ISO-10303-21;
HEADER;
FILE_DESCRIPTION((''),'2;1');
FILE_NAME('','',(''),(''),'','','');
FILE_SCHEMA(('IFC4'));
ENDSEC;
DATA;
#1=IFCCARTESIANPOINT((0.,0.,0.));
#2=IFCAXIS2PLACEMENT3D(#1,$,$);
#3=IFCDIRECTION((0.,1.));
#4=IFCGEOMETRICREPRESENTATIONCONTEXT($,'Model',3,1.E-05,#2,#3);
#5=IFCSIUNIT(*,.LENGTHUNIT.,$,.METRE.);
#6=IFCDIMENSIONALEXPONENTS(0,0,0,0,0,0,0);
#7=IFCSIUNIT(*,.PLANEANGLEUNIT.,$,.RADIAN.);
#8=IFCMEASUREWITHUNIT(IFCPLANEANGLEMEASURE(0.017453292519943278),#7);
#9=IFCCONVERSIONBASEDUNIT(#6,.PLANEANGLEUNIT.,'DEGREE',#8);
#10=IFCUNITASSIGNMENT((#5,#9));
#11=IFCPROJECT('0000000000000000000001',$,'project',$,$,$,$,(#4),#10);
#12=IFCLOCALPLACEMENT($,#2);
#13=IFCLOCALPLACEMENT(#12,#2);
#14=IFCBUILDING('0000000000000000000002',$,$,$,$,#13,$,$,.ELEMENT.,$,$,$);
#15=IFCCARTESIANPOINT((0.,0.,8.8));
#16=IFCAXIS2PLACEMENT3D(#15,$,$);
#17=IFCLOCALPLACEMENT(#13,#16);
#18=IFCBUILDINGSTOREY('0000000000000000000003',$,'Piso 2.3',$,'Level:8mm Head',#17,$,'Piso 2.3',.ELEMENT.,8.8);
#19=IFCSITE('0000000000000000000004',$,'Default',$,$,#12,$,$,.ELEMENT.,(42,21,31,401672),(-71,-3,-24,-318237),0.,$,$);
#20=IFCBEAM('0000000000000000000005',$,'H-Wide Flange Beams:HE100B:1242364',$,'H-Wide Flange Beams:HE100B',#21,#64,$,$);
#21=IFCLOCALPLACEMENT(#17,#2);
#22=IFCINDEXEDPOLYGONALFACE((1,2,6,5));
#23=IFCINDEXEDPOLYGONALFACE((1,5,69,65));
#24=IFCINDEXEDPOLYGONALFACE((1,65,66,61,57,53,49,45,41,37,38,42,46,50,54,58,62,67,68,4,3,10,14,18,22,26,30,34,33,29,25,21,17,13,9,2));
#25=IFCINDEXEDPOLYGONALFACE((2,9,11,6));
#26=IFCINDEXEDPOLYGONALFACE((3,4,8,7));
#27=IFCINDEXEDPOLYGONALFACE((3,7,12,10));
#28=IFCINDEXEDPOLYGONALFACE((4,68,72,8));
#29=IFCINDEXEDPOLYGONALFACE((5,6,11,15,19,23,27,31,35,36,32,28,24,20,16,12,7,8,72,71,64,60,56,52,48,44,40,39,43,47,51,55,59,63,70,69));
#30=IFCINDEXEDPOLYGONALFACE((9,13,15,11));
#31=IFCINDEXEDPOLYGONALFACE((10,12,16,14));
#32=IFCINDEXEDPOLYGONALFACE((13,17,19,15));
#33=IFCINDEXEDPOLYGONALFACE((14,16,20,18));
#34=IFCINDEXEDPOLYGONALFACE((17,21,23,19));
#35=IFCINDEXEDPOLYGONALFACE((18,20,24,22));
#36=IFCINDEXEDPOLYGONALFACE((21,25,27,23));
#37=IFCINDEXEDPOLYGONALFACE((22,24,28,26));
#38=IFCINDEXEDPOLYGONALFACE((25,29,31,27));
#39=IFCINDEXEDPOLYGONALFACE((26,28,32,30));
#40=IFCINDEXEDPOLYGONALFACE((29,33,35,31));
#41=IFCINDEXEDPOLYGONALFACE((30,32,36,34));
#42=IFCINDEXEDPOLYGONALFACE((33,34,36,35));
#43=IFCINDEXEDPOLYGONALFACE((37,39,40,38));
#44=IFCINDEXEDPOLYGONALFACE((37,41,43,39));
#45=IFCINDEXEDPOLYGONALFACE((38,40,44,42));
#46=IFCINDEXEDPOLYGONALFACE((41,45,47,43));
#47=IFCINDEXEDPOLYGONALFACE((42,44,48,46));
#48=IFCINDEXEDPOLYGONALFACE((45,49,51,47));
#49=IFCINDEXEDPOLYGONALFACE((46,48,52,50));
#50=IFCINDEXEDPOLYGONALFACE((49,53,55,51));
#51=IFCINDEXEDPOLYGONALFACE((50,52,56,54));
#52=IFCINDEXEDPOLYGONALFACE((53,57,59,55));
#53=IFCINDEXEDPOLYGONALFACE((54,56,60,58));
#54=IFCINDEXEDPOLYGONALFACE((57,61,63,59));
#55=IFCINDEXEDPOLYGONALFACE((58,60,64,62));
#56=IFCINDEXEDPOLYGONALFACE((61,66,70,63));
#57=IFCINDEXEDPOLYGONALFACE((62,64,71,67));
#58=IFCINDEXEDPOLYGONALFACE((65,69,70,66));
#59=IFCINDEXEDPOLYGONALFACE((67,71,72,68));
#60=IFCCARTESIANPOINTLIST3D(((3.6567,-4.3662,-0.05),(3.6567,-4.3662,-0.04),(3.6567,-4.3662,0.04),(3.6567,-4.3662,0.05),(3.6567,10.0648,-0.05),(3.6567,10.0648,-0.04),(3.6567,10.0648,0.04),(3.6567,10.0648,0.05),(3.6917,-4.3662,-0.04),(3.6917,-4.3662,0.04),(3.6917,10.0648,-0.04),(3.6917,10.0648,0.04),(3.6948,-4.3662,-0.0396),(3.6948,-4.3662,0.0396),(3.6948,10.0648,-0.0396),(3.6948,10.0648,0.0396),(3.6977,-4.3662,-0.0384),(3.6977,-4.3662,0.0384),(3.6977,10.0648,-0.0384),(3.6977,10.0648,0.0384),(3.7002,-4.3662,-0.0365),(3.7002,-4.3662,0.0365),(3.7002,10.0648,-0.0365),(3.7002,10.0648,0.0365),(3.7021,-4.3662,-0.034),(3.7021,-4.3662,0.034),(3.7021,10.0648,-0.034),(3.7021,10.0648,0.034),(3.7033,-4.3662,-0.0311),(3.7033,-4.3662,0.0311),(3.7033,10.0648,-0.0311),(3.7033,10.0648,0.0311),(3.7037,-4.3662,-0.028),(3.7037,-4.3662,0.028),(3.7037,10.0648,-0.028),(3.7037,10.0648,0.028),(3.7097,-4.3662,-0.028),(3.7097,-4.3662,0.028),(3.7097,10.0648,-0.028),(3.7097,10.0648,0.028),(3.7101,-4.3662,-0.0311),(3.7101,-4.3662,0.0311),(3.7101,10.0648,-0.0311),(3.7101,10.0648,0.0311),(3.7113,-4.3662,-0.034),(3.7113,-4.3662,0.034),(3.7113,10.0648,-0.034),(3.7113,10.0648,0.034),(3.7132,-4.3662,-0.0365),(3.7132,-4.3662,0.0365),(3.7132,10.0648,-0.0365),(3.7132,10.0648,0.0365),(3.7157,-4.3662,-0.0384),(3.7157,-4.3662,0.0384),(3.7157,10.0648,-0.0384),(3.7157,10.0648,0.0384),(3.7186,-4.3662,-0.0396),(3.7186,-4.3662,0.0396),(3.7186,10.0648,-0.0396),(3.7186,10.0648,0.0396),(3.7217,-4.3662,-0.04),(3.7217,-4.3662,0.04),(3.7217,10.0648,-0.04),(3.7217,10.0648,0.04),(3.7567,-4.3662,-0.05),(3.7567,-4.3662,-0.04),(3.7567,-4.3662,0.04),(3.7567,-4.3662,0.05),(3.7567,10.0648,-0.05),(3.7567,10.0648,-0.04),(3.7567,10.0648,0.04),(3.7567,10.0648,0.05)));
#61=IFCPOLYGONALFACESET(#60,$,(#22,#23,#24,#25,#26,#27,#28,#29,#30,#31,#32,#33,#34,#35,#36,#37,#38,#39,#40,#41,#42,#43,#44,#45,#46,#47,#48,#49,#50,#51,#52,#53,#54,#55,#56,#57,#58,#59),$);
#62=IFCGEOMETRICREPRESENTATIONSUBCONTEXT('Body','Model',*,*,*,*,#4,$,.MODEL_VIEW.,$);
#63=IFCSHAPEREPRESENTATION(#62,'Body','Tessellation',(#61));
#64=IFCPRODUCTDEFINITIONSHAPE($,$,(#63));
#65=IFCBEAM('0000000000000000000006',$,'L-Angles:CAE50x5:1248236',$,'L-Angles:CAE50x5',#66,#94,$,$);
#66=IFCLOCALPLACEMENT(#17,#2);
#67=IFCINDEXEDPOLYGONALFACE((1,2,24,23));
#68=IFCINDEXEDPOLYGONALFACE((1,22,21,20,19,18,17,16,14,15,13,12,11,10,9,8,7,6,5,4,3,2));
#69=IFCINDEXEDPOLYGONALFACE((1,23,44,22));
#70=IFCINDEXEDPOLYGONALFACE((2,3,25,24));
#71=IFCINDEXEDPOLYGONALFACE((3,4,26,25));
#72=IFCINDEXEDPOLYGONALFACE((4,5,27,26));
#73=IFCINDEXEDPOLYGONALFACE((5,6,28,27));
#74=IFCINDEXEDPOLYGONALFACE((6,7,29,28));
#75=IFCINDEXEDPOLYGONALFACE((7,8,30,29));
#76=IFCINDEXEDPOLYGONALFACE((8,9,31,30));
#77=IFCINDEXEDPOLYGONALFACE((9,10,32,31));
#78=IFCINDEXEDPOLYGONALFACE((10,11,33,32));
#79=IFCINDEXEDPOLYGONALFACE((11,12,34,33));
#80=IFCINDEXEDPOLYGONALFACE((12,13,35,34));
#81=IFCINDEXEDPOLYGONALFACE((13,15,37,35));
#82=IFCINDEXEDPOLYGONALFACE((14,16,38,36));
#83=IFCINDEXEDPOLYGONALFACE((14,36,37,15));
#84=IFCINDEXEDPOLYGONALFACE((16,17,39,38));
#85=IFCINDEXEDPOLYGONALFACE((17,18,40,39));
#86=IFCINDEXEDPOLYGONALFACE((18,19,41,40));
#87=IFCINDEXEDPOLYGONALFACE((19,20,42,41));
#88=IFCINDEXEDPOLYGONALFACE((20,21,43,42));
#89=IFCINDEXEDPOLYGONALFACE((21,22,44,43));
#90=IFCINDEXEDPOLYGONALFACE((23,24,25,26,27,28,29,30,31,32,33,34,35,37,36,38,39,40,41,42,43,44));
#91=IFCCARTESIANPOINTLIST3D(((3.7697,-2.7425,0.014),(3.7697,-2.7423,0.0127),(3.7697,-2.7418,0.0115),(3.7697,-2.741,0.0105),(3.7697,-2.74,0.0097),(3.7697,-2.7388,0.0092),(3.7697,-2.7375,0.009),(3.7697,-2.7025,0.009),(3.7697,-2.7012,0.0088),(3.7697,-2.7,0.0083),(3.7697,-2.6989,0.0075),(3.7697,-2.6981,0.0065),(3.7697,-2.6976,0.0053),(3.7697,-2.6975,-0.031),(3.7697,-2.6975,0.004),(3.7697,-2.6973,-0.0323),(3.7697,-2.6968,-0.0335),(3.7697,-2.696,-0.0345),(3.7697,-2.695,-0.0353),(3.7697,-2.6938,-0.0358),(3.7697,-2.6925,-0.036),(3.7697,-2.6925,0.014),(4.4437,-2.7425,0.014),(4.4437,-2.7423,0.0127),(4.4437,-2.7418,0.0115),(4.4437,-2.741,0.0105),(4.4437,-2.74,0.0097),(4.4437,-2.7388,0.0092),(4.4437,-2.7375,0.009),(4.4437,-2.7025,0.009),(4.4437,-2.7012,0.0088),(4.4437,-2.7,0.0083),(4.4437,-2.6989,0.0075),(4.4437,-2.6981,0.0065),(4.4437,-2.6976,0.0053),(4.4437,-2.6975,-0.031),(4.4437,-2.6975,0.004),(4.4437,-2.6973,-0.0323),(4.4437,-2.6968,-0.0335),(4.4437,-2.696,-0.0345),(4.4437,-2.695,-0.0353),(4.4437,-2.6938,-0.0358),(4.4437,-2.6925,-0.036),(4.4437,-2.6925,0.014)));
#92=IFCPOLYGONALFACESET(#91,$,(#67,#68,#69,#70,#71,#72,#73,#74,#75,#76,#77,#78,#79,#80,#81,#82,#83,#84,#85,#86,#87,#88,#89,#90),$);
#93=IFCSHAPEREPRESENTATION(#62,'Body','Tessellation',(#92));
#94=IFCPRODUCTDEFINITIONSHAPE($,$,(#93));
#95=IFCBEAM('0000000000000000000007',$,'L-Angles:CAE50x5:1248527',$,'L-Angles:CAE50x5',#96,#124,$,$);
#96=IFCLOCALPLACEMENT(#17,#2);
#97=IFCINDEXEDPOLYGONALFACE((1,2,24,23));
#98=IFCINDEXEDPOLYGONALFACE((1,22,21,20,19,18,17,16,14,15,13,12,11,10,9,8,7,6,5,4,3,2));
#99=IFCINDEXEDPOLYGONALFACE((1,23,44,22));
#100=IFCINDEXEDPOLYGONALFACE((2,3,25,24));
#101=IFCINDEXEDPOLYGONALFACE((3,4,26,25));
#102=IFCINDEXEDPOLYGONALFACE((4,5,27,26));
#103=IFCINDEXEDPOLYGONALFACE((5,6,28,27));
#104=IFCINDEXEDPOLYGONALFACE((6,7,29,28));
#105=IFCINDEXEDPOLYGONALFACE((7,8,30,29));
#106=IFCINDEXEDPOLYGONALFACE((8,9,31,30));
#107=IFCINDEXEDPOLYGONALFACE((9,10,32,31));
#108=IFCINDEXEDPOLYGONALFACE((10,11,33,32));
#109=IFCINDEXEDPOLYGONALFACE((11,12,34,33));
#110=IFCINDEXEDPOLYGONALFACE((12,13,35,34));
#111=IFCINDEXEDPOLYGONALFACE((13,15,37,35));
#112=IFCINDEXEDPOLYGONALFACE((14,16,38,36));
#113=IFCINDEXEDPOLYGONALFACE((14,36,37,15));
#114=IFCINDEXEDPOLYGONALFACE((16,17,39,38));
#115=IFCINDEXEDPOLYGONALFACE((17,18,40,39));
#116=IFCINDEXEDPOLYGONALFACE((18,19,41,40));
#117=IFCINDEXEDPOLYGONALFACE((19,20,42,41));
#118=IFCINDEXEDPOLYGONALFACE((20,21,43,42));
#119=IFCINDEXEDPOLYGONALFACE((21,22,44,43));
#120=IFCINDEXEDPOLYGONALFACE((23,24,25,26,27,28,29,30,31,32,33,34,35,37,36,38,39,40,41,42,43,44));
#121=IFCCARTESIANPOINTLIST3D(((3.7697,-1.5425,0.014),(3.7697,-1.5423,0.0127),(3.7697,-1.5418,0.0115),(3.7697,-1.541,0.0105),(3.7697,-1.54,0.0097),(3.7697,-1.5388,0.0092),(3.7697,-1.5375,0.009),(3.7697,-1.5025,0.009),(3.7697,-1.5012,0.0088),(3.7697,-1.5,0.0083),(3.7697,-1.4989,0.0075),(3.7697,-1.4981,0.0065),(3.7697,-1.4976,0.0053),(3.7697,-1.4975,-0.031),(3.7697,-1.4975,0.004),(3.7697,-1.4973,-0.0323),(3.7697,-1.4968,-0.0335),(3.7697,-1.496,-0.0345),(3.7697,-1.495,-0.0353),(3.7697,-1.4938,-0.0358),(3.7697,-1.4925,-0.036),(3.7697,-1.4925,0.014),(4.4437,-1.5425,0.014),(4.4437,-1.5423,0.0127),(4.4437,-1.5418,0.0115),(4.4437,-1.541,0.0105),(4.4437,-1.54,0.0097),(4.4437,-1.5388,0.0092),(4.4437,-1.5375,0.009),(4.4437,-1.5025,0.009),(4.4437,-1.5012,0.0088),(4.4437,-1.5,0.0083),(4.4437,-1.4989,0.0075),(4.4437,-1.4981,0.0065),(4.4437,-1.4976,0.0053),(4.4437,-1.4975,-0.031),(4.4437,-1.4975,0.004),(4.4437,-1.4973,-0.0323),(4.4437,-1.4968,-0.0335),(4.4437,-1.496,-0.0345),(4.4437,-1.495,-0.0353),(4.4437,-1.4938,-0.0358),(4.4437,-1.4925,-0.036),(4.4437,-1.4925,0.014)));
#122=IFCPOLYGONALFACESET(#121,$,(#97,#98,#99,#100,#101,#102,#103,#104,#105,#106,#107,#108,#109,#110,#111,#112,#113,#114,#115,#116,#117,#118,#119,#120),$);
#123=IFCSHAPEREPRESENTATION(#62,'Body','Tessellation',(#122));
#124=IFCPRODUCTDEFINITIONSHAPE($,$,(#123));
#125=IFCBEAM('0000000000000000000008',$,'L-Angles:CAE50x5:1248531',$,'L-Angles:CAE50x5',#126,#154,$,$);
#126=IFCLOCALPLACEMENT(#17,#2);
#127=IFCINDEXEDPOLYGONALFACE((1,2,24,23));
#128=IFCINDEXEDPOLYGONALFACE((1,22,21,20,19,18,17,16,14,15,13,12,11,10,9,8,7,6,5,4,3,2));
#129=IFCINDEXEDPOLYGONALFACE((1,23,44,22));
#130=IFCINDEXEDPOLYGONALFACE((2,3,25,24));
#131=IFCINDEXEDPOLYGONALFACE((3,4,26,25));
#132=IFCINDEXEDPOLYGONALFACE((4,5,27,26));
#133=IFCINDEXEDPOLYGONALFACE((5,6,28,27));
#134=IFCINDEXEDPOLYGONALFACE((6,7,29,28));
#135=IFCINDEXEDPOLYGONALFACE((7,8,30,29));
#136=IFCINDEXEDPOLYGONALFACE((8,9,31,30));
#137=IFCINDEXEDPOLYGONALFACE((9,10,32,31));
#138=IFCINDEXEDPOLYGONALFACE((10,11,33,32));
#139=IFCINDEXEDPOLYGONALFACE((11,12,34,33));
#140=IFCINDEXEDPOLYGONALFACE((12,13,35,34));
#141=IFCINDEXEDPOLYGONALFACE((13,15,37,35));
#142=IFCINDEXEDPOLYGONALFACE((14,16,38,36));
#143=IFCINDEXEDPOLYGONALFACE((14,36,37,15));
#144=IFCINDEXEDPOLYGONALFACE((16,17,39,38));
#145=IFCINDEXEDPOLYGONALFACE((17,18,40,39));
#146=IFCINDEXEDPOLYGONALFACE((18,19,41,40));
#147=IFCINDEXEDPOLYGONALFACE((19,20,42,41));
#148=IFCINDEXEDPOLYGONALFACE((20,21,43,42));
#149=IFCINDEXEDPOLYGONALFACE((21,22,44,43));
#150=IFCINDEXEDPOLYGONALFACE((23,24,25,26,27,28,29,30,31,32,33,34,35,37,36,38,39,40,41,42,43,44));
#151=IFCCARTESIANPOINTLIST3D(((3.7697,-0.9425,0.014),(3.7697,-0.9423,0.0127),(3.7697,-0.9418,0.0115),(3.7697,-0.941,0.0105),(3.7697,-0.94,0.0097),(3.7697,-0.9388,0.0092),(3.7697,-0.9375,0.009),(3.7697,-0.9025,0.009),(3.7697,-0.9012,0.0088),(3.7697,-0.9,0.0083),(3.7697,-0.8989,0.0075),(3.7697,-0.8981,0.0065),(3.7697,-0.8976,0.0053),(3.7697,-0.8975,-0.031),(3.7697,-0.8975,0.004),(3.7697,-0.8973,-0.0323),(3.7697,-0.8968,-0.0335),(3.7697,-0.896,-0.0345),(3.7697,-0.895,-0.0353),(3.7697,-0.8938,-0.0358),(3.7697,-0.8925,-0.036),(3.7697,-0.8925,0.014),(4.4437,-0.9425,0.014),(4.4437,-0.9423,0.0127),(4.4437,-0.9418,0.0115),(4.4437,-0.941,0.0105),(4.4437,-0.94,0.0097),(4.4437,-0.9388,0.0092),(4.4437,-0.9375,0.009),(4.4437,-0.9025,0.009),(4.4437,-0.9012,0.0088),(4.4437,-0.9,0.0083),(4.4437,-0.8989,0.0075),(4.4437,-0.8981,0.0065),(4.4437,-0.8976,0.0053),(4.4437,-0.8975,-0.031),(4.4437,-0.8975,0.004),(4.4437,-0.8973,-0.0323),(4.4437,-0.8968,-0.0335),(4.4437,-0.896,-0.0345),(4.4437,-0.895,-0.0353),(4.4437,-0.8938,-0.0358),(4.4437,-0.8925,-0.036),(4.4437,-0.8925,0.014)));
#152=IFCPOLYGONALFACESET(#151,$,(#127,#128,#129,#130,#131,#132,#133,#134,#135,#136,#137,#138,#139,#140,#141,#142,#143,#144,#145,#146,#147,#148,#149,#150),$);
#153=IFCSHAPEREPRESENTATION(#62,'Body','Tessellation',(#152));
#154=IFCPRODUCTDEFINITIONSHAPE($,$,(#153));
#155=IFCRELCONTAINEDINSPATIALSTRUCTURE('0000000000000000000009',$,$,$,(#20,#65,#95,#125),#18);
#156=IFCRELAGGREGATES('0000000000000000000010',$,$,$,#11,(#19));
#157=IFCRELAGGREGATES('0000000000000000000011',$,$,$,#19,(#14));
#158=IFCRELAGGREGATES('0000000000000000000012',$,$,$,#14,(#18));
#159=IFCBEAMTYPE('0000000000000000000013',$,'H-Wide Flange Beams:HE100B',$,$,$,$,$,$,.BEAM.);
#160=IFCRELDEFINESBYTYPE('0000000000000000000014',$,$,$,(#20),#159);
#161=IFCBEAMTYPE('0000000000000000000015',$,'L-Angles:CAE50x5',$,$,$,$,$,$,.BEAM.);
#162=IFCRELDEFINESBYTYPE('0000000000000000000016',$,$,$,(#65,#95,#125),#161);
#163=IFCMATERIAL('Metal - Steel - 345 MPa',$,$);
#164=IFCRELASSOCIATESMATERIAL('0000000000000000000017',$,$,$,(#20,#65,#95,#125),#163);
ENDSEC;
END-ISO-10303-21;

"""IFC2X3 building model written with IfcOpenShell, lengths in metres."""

from ifc_helpers import new_model, entity, si_unit, converted_unit, direction, frame, frame_2d, origin, place, context, subcontext, project, spatial, polyline, circle_curve, parameter, trimmed, segment, composite_curve, i_section, outline, extrude, material, type_object, element, save


model = new_model("IFC2X3")

# Units and contexts
model_context = context("Model", 3, precision=1e-05, world=origin(), true_north=direction((0.0, 1.0)))
body_context = subcontext(model_context, "Body", "Model", "MODEL_VIEW")
ifc_project = project(units=[si_unit("LENGTHUNIT", "METRE"), converted_unit("PLANEANGLEUNIT", "DEGREE", entity("IfcPlaneAngleMeasure", 0.017453292519943278), si_unit("PLANEANGLEUNIT", "RADIAN"), dimensions=[0, 0, 0, 0, 0, 0, 0])], contexts=[model_context])

# Site, building, storey
site_placement = place(None, origin())
site = spatial("IfcSite", under=ifc_project, at=site_placement, Name="Default", CompositionType="ELEMENT", RefLatitude=(42, 21, 31, 401672), RefLongitude=(-71, -3, -24, -318237), RefElevation=0.0)
building_placement = place(site_placement, origin())
building = spatial("IfcBuilding", under=site, at=building_placement, CompositionType="ELEMENT")
storey_placement = place(building_placement, frame((0.0, 0.0, 8.8)))
storey = spatial("IfcBuildingStorey", under=building, at=storey_placement, Name="Piso 2.3", ObjectType="Level:8mm Head", LongName="Piso 2.3", CompositionType="ELEMENT", Elevation=8.8)

# Beams
ifc_material_1 = material(Name="Metal - Steel - 345 MPa")
beam_type_1 = type_object("IfcBeamType", Name="H-Wide Flange Beams:HE100B", PredefinedType="BEAM")
beam_1_placement = place(storey_placement, frame((3.7067, -4.3265, 0.0), z_axis=(0.0, 0.0, 1.0), x_axis=(0.0, 1.0, 0.0)))
element("IfcBeam", 1, at=beam_1_placement, inside=storey, type_object=beam_type_1, material=ifc_material_1, Name="H-Wide Flange Beams:HE100B:1242364", ObjectType="H-Wide Flange Beams:HE100B", context=body_context, shape_type="SweptSolid", body=[
    extrude(i_section(OverallWidth=0.1, OverallDepth=0.1, WebThickness=0.006, FlangeThickness=0.01, FilletRadius=0.012, at=frame_2d((0.0, 0.0), x_axis=(0.0, 1.0))), frame((-0.0397, 0.0, 0.0), z_axis=(1.0, 0.0, 0.0), x_axis=(0.0, 0.0, -1.0)), (0.0, 0.0, 1.0), 14.431),
])
beam_type_2 = type_object("IfcBeamType", Name="L-Angles:CAE50x5", PredefinedType="BEAM")
beam_2_placement = place(storey_placement, frame((3.7067, -2.7065, 0.0)))
element("IfcBeam", 2, at=beam_2_placement, inside=storey, type_object=beam_type_2, material=ifc_material_1, Name="L-Angles:CAE50x5:1248236", ObjectType="L-Angles:CAE50x5", context=body_context, shape_type="SweptSolid", body=[
    extrude(outline(composite_curve([segment(polyline([(-0.0336, -0.0164), (0.0164, -0.0164)]), True, "CONTINUOUS"), segment(polyline([(0.0164, -0.0164), (0.0164, 0.0336)]), True, "CONTINUOUS"), segment(trimmed(circle_curve(frame_2d((0.0164, 0.0286), x_axis=(0.0, 1.0)), 0.005), [parameter(0.0)], [parameter(90.0)], True, "PARAMETER"), True, "CONTINUOUS"), segment(polyline([(0.0114, 0.0286), (0.0114, -0.0064)]), True, "CONTINUOUS"), segment(trimmed(circle_curve(frame_2d((0.0064, -0.0064), x_axis=(1.0, 0.0)), 0.005), [parameter(270.0)], [parameter(0.0)], True, "PARAMETER"), False, "CONTINUOUS"), segment(polyline([(0.0064, -0.0114), (-0.0286, -0.0114)]), True, "CONTINUOUS"), segment(trimmed(circle_curve(frame_2d((-0.0286, -0.0164), x_axis=(0.0, 1.0)), 0.005), [parameter(0.0)], [parameter(90.0)], True, "PARAMETER"), True, "CONTINUOUS")], self_intersect=False)), frame((0.063, -0.0024, -0.0024), z_axis=(1.0, 0.0, 0.0), x_axis=(0.0, 0.0, 1.0)), (0.0, 0.0, 1.0), 0.674),
])
beam_3_placement = place(storey_placement, frame((3.7067, -1.5065, 0.0)))
element("IfcBeam", 3, at=beam_3_placement, inside=storey, type_object=beam_type_2, material=ifc_material_1, Name="L-Angles:CAE50x5:1248527", ObjectType="L-Angles:CAE50x5", context=body_context, shape_type="SweptSolid", body=[
    extrude(outline(composite_curve([segment(polyline([(-0.0336, -0.0164), (0.0164, -0.0164)]), True, "CONTINUOUS"), segment(polyline([(0.0164, -0.0164), (0.0164, 0.0336)]), True, "CONTINUOUS"), segment(trimmed(circle_curve(frame_2d((0.0164, 0.0286), x_axis=(0.0, 1.0)), 0.005), [parameter(0.0)], [parameter(90.0)], True, "PARAMETER"), True, "CONTINUOUS"), segment(polyline([(0.0114, 0.0286), (0.0114, -0.0064)]), True, "CONTINUOUS"), segment(trimmed(circle_curve(frame_2d((0.0064, -0.0064), x_axis=(1.0, 0.0)), 0.005), [parameter(270.0)], [parameter(0.0)], True, "PARAMETER"), False, "CONTINUOUS"), segment(polyline([(0.0064, -0.0114), (-0.0286, -0.0114)]), True, "CONTINUOUS"), segment(trimmed(circle_curve(frame_2d((-0.0286, -0.0164), x_axis=(0.0, 1.0)), 0.005), [parameter(0.0)], [parameter(90.0)], True, "PARAMETER"), True, "CONTINUOUS")], self_intersect=False)), frame((0.063, -0.0024, -0.0024), z_axis=(1.0, 0.0, 0.0), x_axis=(0.0, 0.0, 1.0)), (0.0, 0.0, 1.0), 0.674),
])
beam_4_placement = place(storey_placement, frame((3.7067, -0.9065, 0.0)))
element("IfcBeam", 4, at=beam_4_placement, inside=storey, type_object=beam_type_2, material=ifc_material_1, Name="L-Angles:CAE50x5:1248531", ObjectType="L-Angles:CAE50x5", context=body_context, shape_type="SweptSolid", body=[
    extrude(outline(composite_curve([segment(polyline([(-0.0336, -0.0164), (0.0164, -0.0164)]), True, "CONTINUOUS"), segment(polyline([(0.0164, -0.0164), (0.0164, 0.0336)]), True, "CONTINUOUS"), segment(trimmed(circle_curve(frame_2d((0.0164, 0.0286), x_axis=(0.0, 1.0)), 0.005), [parameter(0.0)], [parameter(90.0)], True, "PARAMETER"), True, "CONTINUOUS"), segment(polyline([(0.0114, 0.0286), (0.0114, -0.0064)]), True, "CONTINUOUS"), segment(trimmed(circle_curve(frame_2d((0.0064, -0.0064), x_axis=(1.0, 0.0)), 0.005), [parameter(270.0)], [parameter(0.0)], True, "PARAMETER"), False, "CONTINUOUS"), segment(polyline([(0.0064, -0.0114), (-0.0286, -0.0114)]), True, "CONTINUOUS"), segment(trimmed(circle_curve(frame_2d((-0.0286, -0.0164), x_axis=(0.0, 1.0)), 0.005), [parameter(0.0)], [parameter(90.0)], True, "PARAMETER"), True, "CONTINUOUS")], self_intersect=False)), frame((0.063, -0.0024, -0.0024), z_axis=(1.0, 0.0, 0.0), x_axis=(0.0, 0.0, 1.0)), (0.0, 0.0, 1.0), 0.674),
])

save(model, "model.ifc")
